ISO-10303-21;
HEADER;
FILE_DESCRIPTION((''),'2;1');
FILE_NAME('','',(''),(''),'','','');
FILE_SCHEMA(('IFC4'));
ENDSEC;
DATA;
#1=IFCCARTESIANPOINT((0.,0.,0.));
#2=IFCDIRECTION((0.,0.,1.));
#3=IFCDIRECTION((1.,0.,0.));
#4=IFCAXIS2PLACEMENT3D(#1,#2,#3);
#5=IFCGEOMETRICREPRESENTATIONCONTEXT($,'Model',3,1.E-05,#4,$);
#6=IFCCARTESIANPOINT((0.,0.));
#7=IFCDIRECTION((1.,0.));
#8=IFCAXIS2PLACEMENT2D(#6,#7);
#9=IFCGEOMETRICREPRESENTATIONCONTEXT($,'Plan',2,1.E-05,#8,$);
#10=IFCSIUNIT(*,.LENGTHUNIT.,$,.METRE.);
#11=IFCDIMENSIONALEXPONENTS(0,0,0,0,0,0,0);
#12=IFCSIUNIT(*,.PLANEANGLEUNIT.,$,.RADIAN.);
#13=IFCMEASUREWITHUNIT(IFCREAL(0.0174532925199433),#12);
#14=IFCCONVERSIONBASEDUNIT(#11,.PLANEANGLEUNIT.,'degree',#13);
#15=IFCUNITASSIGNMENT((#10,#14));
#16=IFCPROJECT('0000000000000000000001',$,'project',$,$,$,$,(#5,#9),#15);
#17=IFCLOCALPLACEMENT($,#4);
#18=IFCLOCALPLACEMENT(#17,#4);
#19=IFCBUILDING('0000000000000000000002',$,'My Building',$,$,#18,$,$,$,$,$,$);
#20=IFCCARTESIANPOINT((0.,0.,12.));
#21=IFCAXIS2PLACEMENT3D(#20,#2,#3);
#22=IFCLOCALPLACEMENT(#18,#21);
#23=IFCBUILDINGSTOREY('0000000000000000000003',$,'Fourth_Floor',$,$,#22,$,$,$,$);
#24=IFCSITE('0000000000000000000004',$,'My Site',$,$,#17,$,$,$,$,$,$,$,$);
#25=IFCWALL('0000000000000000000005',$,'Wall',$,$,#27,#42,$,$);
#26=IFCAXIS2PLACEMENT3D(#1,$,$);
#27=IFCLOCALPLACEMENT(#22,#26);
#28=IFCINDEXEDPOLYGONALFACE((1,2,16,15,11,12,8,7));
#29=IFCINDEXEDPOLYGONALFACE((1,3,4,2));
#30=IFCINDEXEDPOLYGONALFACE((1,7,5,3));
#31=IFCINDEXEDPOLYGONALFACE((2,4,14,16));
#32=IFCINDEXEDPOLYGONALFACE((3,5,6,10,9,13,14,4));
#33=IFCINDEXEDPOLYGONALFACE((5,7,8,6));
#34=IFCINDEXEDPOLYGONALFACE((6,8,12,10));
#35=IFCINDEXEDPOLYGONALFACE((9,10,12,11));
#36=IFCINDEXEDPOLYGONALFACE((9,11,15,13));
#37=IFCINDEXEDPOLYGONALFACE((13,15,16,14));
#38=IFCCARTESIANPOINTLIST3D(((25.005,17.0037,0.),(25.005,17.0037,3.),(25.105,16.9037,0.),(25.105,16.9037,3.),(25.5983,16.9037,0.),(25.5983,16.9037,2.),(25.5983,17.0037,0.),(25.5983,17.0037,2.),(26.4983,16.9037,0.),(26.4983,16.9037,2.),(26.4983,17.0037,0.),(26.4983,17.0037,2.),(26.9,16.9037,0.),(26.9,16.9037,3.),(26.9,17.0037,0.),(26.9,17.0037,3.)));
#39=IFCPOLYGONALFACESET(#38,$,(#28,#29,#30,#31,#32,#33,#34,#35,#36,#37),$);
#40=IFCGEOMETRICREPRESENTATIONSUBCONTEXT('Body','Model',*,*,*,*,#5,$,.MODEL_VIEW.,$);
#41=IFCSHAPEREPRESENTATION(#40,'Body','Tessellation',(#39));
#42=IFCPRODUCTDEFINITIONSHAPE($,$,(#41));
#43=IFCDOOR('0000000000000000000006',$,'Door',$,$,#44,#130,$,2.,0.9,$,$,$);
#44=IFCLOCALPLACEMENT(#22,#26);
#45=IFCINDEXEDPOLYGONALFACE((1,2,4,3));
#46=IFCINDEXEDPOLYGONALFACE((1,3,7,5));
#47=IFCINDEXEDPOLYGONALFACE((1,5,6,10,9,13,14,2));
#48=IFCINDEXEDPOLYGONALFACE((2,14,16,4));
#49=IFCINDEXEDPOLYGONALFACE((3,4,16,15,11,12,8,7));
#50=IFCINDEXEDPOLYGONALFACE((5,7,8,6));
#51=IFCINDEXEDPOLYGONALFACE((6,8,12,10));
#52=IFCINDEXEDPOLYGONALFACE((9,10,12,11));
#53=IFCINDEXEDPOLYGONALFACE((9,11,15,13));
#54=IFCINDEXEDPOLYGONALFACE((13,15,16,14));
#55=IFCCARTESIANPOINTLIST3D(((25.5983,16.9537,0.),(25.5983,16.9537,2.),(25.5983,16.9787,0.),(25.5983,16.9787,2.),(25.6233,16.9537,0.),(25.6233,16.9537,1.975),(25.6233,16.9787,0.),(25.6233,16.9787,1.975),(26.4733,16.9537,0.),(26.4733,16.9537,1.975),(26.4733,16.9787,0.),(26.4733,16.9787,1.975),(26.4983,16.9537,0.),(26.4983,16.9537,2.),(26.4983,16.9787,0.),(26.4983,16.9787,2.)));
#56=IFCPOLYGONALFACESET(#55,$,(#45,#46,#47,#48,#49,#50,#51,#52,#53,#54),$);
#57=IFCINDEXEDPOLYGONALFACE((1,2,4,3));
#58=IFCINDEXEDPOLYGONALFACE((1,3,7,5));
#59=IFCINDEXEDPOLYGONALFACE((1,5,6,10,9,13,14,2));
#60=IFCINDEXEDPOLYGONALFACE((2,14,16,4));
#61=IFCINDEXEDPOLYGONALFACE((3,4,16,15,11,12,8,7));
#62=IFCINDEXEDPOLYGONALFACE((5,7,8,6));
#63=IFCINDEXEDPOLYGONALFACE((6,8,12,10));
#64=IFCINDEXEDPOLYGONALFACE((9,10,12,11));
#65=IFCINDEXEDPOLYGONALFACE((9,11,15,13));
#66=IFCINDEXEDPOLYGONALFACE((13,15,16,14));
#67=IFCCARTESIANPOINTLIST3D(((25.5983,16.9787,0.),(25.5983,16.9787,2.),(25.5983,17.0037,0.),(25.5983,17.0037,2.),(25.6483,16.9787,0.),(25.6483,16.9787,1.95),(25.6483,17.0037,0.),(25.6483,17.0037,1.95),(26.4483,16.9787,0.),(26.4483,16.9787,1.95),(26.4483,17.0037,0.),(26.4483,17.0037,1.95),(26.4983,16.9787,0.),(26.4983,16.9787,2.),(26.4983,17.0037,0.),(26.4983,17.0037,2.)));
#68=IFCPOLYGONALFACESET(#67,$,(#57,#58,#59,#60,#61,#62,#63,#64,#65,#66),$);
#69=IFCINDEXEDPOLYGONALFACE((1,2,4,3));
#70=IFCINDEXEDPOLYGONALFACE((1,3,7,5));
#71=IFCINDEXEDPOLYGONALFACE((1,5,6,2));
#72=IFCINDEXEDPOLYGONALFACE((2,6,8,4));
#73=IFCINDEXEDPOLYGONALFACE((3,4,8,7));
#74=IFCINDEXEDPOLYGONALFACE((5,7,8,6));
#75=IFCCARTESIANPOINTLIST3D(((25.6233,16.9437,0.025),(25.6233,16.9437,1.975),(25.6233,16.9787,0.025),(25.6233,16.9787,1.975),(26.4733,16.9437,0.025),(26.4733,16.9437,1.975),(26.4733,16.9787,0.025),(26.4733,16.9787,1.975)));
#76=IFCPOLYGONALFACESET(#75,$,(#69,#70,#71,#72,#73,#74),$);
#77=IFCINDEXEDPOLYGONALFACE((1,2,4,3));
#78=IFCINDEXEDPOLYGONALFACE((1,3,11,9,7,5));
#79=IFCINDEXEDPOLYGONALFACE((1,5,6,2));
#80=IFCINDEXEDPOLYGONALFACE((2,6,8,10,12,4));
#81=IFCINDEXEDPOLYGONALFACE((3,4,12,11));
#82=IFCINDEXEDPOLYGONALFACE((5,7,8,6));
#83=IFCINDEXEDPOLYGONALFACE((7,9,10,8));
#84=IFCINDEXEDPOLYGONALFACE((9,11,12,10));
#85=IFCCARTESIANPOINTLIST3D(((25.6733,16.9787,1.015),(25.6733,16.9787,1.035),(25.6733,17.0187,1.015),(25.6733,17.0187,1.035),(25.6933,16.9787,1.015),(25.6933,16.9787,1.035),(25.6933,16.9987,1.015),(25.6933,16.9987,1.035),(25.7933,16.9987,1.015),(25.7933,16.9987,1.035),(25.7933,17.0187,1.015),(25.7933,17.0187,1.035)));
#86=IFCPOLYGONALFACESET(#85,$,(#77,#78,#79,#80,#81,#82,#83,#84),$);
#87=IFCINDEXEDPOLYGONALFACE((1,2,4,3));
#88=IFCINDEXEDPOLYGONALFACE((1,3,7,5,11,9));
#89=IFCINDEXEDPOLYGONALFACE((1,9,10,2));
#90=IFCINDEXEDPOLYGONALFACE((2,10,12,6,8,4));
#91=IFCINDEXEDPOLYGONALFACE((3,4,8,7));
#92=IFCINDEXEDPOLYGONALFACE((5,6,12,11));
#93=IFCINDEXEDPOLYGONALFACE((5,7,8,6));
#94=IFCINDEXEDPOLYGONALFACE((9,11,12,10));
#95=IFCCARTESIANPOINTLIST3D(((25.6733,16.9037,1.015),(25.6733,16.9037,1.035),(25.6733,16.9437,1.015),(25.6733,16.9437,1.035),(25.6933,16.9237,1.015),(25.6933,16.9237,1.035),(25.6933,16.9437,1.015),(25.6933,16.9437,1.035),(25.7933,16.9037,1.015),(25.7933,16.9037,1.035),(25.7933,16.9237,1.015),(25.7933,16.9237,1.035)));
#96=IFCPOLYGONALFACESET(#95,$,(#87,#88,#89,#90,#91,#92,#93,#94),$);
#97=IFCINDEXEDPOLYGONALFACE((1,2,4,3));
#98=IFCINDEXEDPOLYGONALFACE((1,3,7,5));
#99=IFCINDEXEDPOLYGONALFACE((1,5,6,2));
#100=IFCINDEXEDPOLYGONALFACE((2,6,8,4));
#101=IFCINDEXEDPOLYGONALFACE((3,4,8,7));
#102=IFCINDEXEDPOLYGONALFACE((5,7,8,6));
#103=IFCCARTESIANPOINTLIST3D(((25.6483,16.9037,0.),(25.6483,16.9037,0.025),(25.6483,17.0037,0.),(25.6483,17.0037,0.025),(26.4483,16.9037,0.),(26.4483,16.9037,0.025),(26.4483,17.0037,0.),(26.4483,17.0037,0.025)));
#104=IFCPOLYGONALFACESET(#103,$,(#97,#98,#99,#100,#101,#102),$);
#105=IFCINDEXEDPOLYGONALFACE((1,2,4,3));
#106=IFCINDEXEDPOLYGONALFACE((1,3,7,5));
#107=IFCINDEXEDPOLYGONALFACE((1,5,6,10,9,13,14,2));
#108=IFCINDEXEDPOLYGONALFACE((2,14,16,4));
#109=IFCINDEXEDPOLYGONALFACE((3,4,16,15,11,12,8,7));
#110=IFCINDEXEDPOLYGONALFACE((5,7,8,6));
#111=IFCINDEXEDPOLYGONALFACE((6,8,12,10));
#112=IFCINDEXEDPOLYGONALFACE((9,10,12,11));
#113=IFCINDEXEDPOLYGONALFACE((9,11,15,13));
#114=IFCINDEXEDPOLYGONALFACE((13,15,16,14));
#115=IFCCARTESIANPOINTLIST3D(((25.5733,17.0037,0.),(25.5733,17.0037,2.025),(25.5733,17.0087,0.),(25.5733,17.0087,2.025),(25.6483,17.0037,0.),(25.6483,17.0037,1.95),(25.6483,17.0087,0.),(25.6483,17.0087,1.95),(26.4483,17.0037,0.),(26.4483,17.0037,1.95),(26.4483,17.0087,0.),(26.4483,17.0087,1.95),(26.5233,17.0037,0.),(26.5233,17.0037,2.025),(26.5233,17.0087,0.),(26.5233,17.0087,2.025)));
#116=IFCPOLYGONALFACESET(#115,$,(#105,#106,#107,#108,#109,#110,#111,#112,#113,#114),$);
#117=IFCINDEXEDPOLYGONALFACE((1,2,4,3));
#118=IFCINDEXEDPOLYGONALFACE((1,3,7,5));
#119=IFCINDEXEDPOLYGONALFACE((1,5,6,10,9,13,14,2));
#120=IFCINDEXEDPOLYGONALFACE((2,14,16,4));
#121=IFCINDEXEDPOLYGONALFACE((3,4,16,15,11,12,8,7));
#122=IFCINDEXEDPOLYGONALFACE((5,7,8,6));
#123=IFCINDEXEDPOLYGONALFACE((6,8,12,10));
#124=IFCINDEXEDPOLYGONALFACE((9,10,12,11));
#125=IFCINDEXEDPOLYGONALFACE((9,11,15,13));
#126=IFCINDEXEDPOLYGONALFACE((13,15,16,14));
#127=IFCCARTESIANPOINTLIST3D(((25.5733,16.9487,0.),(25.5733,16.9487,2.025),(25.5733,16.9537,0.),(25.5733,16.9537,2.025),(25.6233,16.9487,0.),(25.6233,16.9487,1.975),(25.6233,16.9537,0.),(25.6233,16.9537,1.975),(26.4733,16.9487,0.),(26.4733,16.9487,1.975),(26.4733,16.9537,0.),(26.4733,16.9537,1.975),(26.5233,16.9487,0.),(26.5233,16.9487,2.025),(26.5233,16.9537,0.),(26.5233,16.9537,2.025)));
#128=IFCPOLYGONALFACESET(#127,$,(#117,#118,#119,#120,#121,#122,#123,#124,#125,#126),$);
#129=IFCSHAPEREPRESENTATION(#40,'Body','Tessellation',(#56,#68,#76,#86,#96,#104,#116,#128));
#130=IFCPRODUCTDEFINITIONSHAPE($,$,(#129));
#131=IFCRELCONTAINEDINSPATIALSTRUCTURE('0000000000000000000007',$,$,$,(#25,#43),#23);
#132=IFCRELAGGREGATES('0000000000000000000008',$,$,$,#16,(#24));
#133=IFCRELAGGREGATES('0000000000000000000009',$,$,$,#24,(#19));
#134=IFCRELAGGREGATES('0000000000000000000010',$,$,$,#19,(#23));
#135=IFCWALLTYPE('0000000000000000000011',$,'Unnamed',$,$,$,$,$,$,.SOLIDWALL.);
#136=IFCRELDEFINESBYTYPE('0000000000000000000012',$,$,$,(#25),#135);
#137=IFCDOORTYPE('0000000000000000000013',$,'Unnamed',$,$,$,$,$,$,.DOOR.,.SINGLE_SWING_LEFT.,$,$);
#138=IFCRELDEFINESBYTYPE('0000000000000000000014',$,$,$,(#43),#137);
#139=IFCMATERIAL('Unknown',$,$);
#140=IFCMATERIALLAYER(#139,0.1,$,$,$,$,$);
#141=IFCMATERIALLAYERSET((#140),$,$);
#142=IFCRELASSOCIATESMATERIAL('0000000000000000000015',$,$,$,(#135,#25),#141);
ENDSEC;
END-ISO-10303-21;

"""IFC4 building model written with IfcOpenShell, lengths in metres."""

from ifc_helpers import new_model, entity, si_unit, converted_unit, frame, origin_with_axes, origin_2d_with_axis, place, context, subcontext, project, spatial, line, indexed_curve, outline, extrude, shape, source, transform, mapped, material, layer, layer_set, layer_usage, type_object, type_shapes, element, fill, save


model = new_model("IFC4")

# Units and contexts
model_context = context("Model", 3, precision=1e-05, world=origin_with_axes())
plan_context = context("Plan", 2, precision=1e-05, world=origin_2d_with_axis())
body_context_1 = subcontext(model_context, "Body", "Model", "MODEL_VIEW")
body_context_2 = subcontext(plan_context, "Body", "Plan", "PLAN_VIEW")
ifc_project = project(units=[si_unit("LENGTHUNIT", "METRE"), converted_unit("PLANEANGLEUNIT", "degree", entity("IfcReal", 0.0174532925199433), si_unit("PLANEANGLEUNIT", "RADIAN"), dimensions=[0, 0, 0, 0, 0, 0, 0])], contexts=[model_context, plan_context])

# Site, building, storey
site_placement = place(None, origin_with_axes())
site = spatial("IfcSite", under=ifc_project, at=site_placement, Name="My Site")
building_placement = place(site_placement, origin_with_axes())
building = spatial("IfcBuilding", under=site, at=building_placement, Name="My Building")
storey_placement = place(building_placement, frame((0.0, 0.0, 12.0), z_axis=(0.0, 0.0, 1.0), x_axis=(1.0, 0.0, 0.0)))
storey = spatial("IfcBuildingStorey", under=building, at=storey_placement, Name="Fourth_Floor")

# Shared definitions
ifc_material = material(Name="Unknown")
ifc_layer = layer(ifc_material, 0.1)
ifc_layer_set = layer_set([ifc_layer])
wall_type = type_object("IfcWallType", Name="Unnamed", PredefinedType="SOLIDWALL", material=ifc_layer_set)

# Wall, opening, door
ifc_layer_usage_1 = layer_usage(ifc_layer_set, "AXIS2", "POSITIVE", 0.0)
wall_1_placement = place(storey_placement, frame((26.9, 17.0037, 0.0), z_axis=(0.0, 0.0, 1.0), x_axis=(-1.0, 0.0, 0.0)))
wall_1 = element("IfcWall", 1, at=wall_1_placement, inside=storey, type_object=wall_type, material=ifc_layer_usage_1, Name="Wall", context=body_context_1, shape_type="SweptSolid", body=[
    extrude(outline(indexed_curve([(0.0, 0.0), (0.0, 0.1), (1.795, 0.1), (1.895, 0.0)], segments=[line(1, 2, 3, 4, 1)])), origin_with_axes(), (0.0, 0.0, 1.0), 3.0),
])
shared_shape_1 = source(origin_with_axes(), body_context_1, "Body", "SweptSolid", [
    extrude(outline(indexed_curve([(0.0, 0.0), (0.9, 0.0), (0.9, 2.0), (0.0, 2.0)], segments=[line(1, 2, 3, 4, 1)])), frame((0.0, -0.6, 0.0), z_axis=(0.0, -1.0, 0.0), x_axis=(1.0, 0.0, 0.0)), (0.0, 0.0, -1.0), 1.2),
])
opening_1_placement = place(wall_1_placement, frame((0.4017, 0.0, 0.0), z_axis=(0.0, 0.0, 1.0), x_axis=(1.0, 0.0, 0.0)))
opening_1 = element("IfcOpeningElement", 2, at=opening_1_placement, cuts=wall_1, PredefinedType="OPENING", context=body_context_1, shape_type="MappedRepresentation", body=[
    mapped(shared_shape_1, transform((0.0, 0.0, 0.0), x_axis=(1.0, 0.0, 0.0), y_axis=(0.0, 1.0, 0.0), z_axis=(0.0, 0.0, 1.0), scale=1.0)),
])
door_type = type_object("IfcDoorType", Name="Unnamed", OperationType="SINGLE_SWING_LEFT", PredefinedType="DOOR")
shared_shape_2 = source(origin_with_axes(), body_context_1, "Body", "SweptSolid", [
    extrude(outline(indexed_curve([(0.0, 0.0), (0.0, 2.0), (0.9, 2.0), (0.9, 0.0), (0.875, 0.0), (0.875, 1.975), (0.025, 1.975), (0.025, 0.0)], segments=[line(1, 2, 3, 4, 5, 6, 7, 8, 1)])), frame((0.0, 0.025, 0.0), z_axis=(0.0, -1.0, 0.0), x_axis=(1.0, 0.0, 0.0)), (0.0, 0.0, -1.0), 0.025),
    extrude(outline(indexed_curve([(0.0, 0.0), (0.0, 2.0), (0.9, 2.0), (0.9, 0.0), (0.85, 0.0), (0.85, 1.95), (0.05, 1.95), (0.05, 0.0)], segments=[line(1, 2, 3, 4, 5, 6, 7, 8, 1)])), frame((0.0, 0.0, 0.0), z_axis=(0.0, -1.0, 0.0), x_axis=(1.0, 0.0, 0.0)), (0.0, 0.0, -1.0), 0.025),
    extrude(outline(indexed_curve([(0.0, 0.0), (0.85, 0.0), (0.85, 0.035), (0.0, 0.035)], segments=[line(1, 2, 3, 4, 1)])), frame((0.025, 0.025, 0.025), z_axis=(0.0, 0.0, 1.0), x_axis=(1.0, 0.0, 0.0)), (0.0, 0.0, 1.0), 1.95),
    extrude(outline(indexed_curve([(0.0, 0.0), (0.0, -0.04), (-0.12, -0.04), (-0.12, -0.02), (-0.02, -0.02), (-0.02, 0.0)], segments=[line(1, 2, 3, 4, 5, 6, 1)])), frame((0.825, 0.025, 1.015), z_axis=(0.0, 0.0, 1.0), x_axis=(1.0, 0.0, 0.0)), (0.0, 0.0, 1.0), 0.02),
    extrude(outline(indexed_curve([(0.0, 0.0), (0.0, 0.04), (-0.12, 0.04), (-0.12, 0.02), (-0.02, 0.02), (-0.02, 0.0)], segments=[line(1, 2, 3, 4, 5, 6, 1)])), frame((0.825, 0.06, 1.015), z_axis=(0.0, 0.0, 1.0), x_axis=(1.0, 0.0, 0.0)), (0.0, 0.0, 1.0), 0.02),
    extrude(outline(indexed_curve([(0.0, 0.0), (0.8, 0.0), (0.8, 0.1), (0.0, 0.1)], segments=[line(1, 2, 3, 4, 1)])), frame((0.05, 0.0, 0.0), z_axis=(0.0, 0.0, 1.0), x_axis=(1.0, 0.0, 0.0)), (0.0, 0.0, 1.0), 0.025),
    extrude(outline(indexed_curve([(0.0, 0.0), (0.0, 2.025), (0.95, 2.025), (0.95, 0.0), (0.875, 0.0), (0.875, 1.95), (0.075, 1.95), (0.075, 0.0)], segments=[line(1, 2, 3, 4, 5, 6, 7, 8, 1)])), frame((-0.025, -0.005, 0.0), z_axis=(0.0, -1.0, 0.0), x_axis=(1.0, 0.0, 0.0)), (0.0, 0.0, -1.0), 0.005),
    extrude(outline(indexed_curve([(0.0, 0.0), (0.0, 2.025), (0.95, 2.025), (0.95, 0.0), (0.9, 0.0), (0.9, 1.975), (0.05, 1.975), (0.05, 0.0)], segments=[line(1, 2, 3, 4, 5, 6, 7, 8, 1)])), frame((-0.025, 0.05, 0.0), z_axis=(0.0, -1.0, 0.0), x_axis=(1.0, 0.0, 0.0)), (0.0, 0.0, -1.0), 0.005),
])
shared_shape_3 = source(origin_with_axes(), body_context_2, "Body", "Curve2D", [
    entity("IfcIndexedPolyCurve", entity("IfcCartesianPointList2D", [[0.0, 0.0], [0.0, 0.05], [0.025, 0.05], [0.025, 0.025], [0.05, 0.025], [0.05, 0.0]]), [entity("IfcLineIndex", [1, 2, 3, 4, 5, 6, 1])]),
    entity("IfcIndexedPolyCurve", entity("IfcCartesianPointList2D", [[0.9, 0.0], [0.9, 0.05], [0.875, 0.05], [0.875, 0.025], [0.85, 0.025], [0.85, 0.0]]), [entity("IfcLineIndex", [1, 2, 3, 4, 5, 6, 1])]),
    entity("IfcTrimmedCurve", entity("IfcEllipse", entity("IfcAxis2Placement2D", entity("IfcCartesianPoint", [0.06, 0.05]), entity("IfcDirection", [1.0, 0.0])), 0.815, 0.85), [entity("IfcCartesianPoint", [0.875, 0.05])], [entity("IfcCartesianPoint", [0.06, 0.9])], True, "CARTESIAN"),
    entity("IfcIndexedPolyCurve", entity("IfcCartesianPointList2D", [[0.025, 0.05], [0.06, 0.05], [0.06, 0.9], [0.025, 0.9]]), [entity("IfcLineIndex", [1, 2, 3, 4, 1])]),
])
type_shapes(door_type, [shared_shape_2, shared_shape_3])
door_1_placement = place(opening_1_placement, frame((0.0, 0.0, 0.0), z_axis=(0.0, 0.0, 1.0), x_axis=(1.0, 0.0, 0.0)))
door_1 = element("IfcDoor", 3, at=door_1_placement, inside=storey, type_object=door_type, Name="Door", OverallHeight=2.0, OverallWidth=0.9, shapes=[
    shape(body_context_1, "Body", "MappedRepresentation", [mapped(shared_shape_2, transform((0.0, 0.0, 0.0), x_axis=(1.0, 0.0, 0.0), y_axis=(0.0, 1.0, 0.0), z_axis=(0.0, 0.0, 1.0), scale=1.0))]),
    shape(body_context_2, "Body", "MappedRepresentation", [mapped(shared_shape_3, transform((0.0, 0.0, 0.0), x_axis=(1.0, 0.0, 0.0), y_axis=(0.0, 1.0, 0.0), z_axis=(0.0, 0.0, 1.0), scale=1.0))]),
])
fill(opening_1, door_1)

save(model, "model.ifc")
